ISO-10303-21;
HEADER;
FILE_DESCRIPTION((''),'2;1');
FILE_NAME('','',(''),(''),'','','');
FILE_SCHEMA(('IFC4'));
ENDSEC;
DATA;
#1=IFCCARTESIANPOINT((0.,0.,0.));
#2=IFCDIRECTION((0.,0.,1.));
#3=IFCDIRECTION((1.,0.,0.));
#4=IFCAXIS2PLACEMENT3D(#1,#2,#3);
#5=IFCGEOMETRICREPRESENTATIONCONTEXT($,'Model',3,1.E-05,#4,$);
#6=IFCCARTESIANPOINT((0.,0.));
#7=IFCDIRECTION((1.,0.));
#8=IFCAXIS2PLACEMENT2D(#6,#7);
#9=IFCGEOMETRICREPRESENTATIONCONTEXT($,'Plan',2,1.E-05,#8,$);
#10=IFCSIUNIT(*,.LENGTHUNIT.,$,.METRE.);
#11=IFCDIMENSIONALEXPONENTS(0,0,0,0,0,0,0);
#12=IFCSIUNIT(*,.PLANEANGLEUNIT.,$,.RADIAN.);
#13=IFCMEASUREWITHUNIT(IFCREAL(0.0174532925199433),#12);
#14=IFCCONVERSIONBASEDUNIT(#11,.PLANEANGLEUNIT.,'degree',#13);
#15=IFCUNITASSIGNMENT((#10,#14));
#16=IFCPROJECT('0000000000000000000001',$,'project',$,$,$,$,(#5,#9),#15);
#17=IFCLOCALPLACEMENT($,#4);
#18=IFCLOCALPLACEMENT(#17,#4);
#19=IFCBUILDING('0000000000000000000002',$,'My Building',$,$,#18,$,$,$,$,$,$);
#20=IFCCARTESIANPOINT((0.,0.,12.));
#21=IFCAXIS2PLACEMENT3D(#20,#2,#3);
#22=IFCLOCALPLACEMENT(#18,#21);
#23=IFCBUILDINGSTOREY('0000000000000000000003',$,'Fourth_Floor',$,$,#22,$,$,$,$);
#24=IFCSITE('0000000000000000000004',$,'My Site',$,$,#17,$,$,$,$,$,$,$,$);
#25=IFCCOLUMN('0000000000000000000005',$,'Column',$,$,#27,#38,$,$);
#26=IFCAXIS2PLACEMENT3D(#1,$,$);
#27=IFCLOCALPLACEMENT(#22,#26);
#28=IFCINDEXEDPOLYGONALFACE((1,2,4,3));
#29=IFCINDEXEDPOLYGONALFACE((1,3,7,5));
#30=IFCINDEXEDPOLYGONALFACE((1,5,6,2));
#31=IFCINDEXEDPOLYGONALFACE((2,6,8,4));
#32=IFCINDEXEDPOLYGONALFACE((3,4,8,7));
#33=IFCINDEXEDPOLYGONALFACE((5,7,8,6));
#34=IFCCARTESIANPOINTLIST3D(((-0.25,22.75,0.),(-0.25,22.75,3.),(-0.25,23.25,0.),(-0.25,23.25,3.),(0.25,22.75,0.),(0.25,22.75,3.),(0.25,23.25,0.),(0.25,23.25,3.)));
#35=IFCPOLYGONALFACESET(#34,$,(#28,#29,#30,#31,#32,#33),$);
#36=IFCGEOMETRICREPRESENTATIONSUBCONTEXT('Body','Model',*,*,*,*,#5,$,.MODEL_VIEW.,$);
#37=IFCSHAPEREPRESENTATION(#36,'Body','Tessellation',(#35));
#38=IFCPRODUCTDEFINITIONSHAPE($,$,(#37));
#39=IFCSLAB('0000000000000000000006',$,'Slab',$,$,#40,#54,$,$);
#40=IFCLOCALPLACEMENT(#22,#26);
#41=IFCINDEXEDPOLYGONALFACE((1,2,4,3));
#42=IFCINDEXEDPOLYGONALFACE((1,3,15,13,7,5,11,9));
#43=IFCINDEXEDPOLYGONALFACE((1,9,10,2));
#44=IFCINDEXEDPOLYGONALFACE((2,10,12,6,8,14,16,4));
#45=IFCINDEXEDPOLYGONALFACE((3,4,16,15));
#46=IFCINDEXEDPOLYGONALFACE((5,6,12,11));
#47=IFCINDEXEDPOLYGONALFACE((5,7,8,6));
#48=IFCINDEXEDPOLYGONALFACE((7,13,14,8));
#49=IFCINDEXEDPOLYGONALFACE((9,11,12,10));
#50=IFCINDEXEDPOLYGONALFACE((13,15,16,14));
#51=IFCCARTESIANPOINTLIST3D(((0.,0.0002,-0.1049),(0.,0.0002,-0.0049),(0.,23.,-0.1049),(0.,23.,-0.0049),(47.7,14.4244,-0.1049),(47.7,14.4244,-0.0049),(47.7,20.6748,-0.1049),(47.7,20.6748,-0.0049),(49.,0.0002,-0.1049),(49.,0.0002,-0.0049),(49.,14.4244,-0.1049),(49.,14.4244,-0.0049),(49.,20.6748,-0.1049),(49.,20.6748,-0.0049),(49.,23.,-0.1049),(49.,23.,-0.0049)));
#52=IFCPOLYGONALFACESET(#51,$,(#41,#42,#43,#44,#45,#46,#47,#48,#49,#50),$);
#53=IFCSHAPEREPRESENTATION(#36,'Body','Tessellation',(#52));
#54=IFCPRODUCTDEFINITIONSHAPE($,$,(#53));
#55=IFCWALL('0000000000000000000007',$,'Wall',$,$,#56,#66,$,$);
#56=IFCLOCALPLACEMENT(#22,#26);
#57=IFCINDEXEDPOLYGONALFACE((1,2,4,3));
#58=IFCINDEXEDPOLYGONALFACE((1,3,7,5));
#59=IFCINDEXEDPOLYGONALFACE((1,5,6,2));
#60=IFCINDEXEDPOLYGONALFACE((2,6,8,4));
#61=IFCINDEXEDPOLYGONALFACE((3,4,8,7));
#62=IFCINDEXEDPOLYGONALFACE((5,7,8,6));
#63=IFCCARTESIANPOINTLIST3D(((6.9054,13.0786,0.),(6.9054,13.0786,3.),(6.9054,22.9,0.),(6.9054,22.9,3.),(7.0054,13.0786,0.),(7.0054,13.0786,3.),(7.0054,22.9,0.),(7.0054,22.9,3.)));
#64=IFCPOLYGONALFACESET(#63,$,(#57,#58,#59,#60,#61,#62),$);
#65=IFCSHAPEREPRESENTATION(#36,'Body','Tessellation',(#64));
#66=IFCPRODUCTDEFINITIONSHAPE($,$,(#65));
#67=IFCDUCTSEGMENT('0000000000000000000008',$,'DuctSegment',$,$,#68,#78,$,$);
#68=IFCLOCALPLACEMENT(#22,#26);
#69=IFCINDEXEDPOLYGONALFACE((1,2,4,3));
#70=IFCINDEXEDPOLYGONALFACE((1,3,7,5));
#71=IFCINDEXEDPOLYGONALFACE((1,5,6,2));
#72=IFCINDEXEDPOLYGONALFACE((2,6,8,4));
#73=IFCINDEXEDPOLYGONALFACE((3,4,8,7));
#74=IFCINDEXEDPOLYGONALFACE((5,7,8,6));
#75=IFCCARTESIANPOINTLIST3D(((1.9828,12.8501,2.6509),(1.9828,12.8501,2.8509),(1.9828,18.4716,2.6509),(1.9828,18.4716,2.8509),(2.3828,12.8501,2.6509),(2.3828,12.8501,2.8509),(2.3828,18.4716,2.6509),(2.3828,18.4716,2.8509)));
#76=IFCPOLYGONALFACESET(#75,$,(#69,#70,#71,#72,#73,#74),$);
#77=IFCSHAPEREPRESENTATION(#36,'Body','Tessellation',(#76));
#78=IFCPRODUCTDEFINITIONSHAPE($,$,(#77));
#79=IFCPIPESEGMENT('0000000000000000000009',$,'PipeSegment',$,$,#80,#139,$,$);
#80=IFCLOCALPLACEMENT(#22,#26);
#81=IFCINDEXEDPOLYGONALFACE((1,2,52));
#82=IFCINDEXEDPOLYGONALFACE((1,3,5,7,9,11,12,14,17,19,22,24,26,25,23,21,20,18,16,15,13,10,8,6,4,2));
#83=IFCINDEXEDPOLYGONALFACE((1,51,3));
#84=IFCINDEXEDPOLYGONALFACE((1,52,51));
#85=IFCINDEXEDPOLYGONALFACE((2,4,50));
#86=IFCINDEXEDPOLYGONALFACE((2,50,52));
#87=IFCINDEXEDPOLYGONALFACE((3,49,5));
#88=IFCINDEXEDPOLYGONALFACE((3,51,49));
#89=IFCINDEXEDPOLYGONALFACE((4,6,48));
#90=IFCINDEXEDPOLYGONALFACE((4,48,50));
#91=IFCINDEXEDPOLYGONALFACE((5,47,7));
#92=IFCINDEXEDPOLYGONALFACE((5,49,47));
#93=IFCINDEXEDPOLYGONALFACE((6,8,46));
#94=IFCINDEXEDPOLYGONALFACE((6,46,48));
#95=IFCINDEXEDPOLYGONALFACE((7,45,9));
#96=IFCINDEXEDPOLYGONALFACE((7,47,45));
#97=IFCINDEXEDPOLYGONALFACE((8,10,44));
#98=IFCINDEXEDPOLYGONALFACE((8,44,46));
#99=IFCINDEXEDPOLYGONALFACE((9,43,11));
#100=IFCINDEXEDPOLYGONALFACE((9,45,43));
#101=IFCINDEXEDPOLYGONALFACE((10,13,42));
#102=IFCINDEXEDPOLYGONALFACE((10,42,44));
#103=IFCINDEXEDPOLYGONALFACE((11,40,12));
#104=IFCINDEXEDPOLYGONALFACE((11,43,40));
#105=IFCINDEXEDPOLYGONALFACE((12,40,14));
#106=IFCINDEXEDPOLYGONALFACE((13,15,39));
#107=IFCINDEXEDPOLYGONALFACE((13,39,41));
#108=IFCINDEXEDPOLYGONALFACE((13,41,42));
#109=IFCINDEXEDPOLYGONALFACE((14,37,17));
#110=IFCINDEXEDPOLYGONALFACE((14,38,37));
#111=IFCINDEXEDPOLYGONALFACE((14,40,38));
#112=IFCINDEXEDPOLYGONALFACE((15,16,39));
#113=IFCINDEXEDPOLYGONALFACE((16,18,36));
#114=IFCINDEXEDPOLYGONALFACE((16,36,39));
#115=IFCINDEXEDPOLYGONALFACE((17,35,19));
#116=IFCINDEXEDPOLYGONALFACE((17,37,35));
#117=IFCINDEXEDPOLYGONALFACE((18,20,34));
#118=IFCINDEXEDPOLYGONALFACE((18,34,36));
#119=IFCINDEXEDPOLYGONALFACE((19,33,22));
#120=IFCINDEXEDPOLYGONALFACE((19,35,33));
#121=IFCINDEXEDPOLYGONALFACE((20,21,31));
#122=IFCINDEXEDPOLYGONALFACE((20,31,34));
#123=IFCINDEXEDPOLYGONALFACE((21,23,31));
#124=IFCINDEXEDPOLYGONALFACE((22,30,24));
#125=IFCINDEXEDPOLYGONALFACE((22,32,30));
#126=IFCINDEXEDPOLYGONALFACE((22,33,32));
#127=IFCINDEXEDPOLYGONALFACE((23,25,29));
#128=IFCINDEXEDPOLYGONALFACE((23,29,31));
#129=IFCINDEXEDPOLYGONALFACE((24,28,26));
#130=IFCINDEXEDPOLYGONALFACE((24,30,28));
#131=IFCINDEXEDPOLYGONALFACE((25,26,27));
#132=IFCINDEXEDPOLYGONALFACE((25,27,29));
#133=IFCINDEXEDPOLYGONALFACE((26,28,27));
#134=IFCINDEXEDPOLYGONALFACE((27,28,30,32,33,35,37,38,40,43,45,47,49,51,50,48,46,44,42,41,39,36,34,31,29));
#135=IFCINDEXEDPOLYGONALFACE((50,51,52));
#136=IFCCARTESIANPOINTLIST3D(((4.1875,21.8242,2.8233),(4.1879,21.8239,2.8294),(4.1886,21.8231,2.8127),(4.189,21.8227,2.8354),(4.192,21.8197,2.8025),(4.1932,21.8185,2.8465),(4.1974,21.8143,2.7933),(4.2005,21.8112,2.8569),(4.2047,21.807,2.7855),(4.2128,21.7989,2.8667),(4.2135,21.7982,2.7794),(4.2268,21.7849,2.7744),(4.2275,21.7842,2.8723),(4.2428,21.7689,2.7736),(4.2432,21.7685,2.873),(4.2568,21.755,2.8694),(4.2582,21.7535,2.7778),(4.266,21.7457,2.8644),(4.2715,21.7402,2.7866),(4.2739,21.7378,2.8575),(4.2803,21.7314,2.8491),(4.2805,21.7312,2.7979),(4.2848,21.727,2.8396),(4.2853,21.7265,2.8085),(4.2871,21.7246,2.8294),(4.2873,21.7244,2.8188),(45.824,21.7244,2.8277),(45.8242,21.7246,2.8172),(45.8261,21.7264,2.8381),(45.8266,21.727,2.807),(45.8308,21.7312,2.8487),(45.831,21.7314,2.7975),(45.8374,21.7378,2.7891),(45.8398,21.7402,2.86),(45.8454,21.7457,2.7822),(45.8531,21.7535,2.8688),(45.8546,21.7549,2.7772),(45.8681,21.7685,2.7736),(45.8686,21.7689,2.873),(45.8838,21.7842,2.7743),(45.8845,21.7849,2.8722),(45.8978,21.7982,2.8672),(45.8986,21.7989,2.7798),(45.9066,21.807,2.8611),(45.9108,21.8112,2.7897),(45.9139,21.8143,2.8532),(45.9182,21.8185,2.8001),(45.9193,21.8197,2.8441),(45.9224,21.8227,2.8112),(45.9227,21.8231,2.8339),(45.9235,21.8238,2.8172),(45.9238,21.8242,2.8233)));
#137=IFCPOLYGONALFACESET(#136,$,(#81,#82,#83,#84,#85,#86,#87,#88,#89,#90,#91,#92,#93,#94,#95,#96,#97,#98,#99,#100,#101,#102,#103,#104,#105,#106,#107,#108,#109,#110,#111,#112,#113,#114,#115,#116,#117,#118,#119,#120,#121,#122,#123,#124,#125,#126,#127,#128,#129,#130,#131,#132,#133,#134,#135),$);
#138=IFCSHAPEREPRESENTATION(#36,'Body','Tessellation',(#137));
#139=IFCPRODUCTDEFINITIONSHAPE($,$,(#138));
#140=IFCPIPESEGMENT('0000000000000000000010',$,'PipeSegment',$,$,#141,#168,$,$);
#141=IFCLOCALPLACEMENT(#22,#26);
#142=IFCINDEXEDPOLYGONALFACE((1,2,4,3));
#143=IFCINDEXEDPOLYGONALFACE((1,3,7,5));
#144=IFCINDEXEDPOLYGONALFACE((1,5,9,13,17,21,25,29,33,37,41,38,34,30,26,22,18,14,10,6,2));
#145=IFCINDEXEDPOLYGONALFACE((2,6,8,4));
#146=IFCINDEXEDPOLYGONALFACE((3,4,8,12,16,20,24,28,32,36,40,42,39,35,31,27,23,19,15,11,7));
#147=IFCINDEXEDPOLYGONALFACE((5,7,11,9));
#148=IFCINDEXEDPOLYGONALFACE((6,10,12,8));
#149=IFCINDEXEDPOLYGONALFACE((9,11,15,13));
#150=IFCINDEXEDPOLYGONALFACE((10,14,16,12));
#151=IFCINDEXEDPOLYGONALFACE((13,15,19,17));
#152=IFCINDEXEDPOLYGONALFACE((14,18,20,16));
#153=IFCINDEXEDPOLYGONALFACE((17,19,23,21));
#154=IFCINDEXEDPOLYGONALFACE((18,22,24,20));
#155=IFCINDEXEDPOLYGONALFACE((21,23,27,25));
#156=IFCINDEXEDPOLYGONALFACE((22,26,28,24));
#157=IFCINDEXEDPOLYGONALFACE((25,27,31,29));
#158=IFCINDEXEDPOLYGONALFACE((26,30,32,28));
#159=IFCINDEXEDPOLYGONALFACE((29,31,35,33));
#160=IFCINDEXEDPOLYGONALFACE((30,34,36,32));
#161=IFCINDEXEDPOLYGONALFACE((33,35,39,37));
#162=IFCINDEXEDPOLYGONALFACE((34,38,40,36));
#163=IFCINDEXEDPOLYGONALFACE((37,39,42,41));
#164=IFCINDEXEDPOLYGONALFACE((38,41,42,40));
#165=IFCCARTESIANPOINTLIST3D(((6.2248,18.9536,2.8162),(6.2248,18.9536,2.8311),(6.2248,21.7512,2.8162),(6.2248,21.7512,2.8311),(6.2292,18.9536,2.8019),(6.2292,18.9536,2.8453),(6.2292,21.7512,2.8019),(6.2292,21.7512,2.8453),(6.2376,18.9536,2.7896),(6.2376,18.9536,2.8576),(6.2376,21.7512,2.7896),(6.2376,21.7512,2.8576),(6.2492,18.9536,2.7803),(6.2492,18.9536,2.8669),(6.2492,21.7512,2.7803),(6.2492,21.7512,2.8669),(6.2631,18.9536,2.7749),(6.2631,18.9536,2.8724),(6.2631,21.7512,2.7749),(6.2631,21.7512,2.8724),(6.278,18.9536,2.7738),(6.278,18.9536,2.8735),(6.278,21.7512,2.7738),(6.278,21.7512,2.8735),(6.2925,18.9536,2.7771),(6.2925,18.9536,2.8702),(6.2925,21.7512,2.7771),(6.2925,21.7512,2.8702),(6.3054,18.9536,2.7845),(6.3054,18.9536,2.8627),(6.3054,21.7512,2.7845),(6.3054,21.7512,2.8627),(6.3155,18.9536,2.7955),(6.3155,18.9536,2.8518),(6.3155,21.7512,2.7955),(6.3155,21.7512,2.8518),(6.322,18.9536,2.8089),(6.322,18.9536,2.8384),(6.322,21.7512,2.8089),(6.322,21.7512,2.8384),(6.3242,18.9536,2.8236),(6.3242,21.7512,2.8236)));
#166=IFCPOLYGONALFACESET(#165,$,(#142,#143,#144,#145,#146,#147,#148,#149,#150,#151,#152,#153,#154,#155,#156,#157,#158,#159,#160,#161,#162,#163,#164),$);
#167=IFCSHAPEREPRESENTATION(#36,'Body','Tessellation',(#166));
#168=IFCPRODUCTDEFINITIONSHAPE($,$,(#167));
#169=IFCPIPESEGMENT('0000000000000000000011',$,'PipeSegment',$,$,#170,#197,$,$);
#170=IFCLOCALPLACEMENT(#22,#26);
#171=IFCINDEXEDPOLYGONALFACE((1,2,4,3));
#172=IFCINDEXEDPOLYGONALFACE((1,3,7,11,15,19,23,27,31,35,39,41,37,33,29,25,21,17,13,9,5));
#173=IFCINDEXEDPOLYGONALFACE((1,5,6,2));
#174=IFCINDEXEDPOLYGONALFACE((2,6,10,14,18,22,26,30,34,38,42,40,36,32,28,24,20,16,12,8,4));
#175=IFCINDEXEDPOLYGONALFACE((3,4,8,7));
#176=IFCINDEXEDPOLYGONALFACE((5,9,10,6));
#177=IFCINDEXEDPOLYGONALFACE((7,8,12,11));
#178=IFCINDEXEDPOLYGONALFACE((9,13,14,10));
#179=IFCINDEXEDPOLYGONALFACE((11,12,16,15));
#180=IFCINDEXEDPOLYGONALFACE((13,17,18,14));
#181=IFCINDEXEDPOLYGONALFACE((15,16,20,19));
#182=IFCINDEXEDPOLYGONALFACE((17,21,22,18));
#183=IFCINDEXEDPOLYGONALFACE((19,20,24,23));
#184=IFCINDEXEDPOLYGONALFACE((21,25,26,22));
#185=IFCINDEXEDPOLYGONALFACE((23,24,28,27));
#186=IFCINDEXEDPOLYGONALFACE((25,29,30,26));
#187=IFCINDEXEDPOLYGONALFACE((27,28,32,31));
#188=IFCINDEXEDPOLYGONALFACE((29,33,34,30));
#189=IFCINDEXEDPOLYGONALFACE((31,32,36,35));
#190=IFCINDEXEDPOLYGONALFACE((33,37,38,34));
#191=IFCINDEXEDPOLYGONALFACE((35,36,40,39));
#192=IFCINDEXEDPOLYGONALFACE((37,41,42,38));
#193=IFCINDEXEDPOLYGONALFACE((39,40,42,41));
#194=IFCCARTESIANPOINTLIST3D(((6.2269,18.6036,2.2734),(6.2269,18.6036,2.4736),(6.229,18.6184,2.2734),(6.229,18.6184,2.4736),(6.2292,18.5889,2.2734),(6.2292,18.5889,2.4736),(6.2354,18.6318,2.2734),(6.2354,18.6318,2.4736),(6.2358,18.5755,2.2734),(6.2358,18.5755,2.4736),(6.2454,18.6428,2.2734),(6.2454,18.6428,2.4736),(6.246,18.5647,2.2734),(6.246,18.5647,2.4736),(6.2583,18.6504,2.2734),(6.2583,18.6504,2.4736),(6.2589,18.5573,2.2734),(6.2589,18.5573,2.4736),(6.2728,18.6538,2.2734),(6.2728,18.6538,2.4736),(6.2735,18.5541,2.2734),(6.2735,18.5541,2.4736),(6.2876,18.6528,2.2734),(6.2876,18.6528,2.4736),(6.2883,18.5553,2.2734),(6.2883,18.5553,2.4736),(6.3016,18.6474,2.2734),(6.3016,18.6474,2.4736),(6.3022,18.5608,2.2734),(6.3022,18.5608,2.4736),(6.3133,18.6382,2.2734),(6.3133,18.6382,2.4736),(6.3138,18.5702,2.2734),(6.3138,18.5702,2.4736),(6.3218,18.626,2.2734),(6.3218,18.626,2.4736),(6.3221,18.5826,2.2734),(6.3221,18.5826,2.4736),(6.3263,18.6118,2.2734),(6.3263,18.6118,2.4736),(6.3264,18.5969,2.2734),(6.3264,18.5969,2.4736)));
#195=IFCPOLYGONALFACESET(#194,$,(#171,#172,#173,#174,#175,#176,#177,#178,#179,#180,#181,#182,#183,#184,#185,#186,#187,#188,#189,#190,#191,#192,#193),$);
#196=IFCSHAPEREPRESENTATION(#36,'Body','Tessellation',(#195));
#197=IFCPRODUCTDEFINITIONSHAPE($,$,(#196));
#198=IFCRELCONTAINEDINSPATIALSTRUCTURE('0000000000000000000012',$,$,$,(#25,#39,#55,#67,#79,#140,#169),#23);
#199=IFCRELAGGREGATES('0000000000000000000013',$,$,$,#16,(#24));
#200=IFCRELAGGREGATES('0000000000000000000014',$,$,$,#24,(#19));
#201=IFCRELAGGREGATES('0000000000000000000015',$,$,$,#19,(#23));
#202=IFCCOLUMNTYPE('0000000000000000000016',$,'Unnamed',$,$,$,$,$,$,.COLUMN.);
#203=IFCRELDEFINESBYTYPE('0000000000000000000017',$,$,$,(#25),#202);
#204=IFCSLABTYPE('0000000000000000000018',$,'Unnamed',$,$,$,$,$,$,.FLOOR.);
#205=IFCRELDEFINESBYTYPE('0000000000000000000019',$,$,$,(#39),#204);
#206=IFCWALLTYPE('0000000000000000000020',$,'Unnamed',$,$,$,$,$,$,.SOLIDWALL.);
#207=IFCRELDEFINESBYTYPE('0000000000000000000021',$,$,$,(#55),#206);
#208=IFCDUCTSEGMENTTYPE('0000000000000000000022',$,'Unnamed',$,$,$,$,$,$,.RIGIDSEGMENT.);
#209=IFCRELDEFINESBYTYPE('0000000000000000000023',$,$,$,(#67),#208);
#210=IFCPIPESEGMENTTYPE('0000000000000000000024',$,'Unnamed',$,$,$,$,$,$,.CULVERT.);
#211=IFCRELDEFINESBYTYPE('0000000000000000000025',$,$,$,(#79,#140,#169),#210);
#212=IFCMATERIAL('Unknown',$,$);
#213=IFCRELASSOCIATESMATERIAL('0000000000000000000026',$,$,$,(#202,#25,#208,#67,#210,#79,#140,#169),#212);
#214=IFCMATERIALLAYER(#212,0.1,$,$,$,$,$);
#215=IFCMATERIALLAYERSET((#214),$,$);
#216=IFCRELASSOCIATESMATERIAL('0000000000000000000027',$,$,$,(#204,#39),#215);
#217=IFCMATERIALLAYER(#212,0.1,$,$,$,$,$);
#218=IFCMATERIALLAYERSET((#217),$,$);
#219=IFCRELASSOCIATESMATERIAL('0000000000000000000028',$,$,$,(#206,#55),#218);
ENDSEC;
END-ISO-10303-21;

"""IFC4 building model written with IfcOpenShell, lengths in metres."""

from ifc_helpers import new_model, entity, si_unit, converted_unit, frame, origin_with_axes, origin_2d_with_axis, place, context, subcontext, project, spatial, line, indexed_curve, rectangle, circle, outline, extrude, clip, halfspace, material, layer, layer_set, layer_usage, material_profile, profile_set, profile_usage, type_object, element, save


model = new_model("IFC4")

# Units and contexts
model_context = context("Model", 3, precision=1e-05, world=origin_with_axes())
plan_context = context("Plan", 2, precision=1e-05, world=origin_2d_with_axis())
body_context_1 = subcontext(model_context, "Body", "Model", "MODEL_VIEW")
ifc_project = project(units=[si_unit("LENGTHUNIT", "METRE"), converted_unit("PLANEANGLEUNIT", "degree", entity("IfcReal", 0.0174532925199433), si_unit("PLANEANGLEUNIT", "RADIAN"), dimensions=[0, 0, 0, 0, 0, 0, 0])], contexts=[model_context, plan_context])

# Site, building, storey
site_placement = place(None, origin_with_axes())
site = spatial("IfcSite", under=ifc_project, at=site_placement, Name="My Site")
building_placement = place(site_placement, origin_with_axes())
building = spatial("IfcBuilding", under=site, at=building_placement, Name="My Building")
storey_placement = place(building_placement, frame((0.0, 0.0, 12.0), z_axis=(0.0, 0.0, 1.0), x_axis=(1.0, 0.0, 0.0)))
storey = spatial("IfcBuildingStorey", under=building, at=storey_placement, Name="Fourth_Floor")

# Column
ifc_material = material(Name="Unknown")
ifc_material_profile_1 = material_profile(ifc_material, rectangle(XDim=0.5, YDim=0.5))
ifc_profile_set_1 = profile_set([ifc_material_profile_1])
ifc_profile_usage_1 = profile_usage(ifc_profile_set_1, cardinal=5)
column_type = type_object("IfcColumnType", Name="Unnamed", PredefinedType="COLUMN", material=ifc_profile_set_1)
column_placement = place(storey_placement, frame((0.0, 23.0, 0.0), z_axis=(0.0, 0.0, 1.0), x_axis=(1.0, 0.0, 0.0)))
element("IfcColumn", 1, at=column_placement, inside=storey, type_object=column_type, material=ifc_profile_usage_1, Name="Column", context=body_context_1, shape_type="SweptSolid", body=[
    extrude(rectangle(XDim=0.5, YDim=0.5), origin_with_axes(), (0.0, 0.0, 1.0), 3.0),
])

# Slab
ifc_layer_1 = layer(ifc_material, 0.1)
ifc_layer_set_1 = layer_set([ifc_layer_1])
ifc_layer_usage_1 = layer_usage(ifc_layer_set_1, "AXIS3", "POSITIVE", -0.1)
slab_type = type_object("IfcSlabType", Name="Unnamed", PredefinedType="FLOOR", material=ifc_layer_set_1)
slab_placement = place(storey_placement, frame((0.0, 23.0, -0.0049), z_axis=(0.0, 0.0, 1.0), x_axis=(1.0, 0.0, 0.0)))
element("IfcSlab", 2, at=slab_placement, inside=storey, type_object=slab_type, material=ifc_layer_usage_1, Name="Slab", context=body_context_1, shape_type="SweptSolid", body=[
    extrude(outline(indexed_curve([(0.0, 0.0), (49.0, 0.0), (49.0, -2.3252), (47.7, -2.3252), (47.7, -8.5756), (49.0, -8.5756), (49.0, -22.9998), (0.0, -22.9998), (0.0, 0.0)])), frame((0.0, 0.0, -0.1), z_axis=(0.0, 0.0, 1.0), x_axis=(1.0, 0.0, 0.0)), (0.0, 0.0, 1.0), 0.1),
])

# Shared definitions
ifc_layer_2 = layer(ifc_material, 0.1)
ifc_layer_set_2 = layer_set([ifc_layer_2])
wall_type = type_object("IfcWallType", Name="Unnamed", PredefinedType="SOLIDWALL", material=ifc_layer_set_2)

# Wall
ifc_layer_usage_2 = layer_usage(ifc_layer_set_2, "AXIS2", "POSITIVE", 0.0)
wall_1_placement = place(storey_placement, frame((6.9054, 22.9, 0.0), z_axis=(0.0, 0.0, 1.0), x_axis=(0.0, -1.0, 0.0)))
element("IfcWall", 3, at=wall_1_placement, inside=storey, type_object=wall_type, material=ifc_layer_usage_2, Name="Wall", context=body_context_1, shape_type="SweptSolid", body=[
    extrude(outline(indexed_curve([(0.0, 0.0), (0.0, 0.1), (9.8214, 0.1), (9.8214, 0.0)], segments=[line(1, 2, 3, 4, 1)])), origin_with_axes(), (0.0, 0.0, 1.0), 3.0),
])

# Duct segment
ifc_material_profile_2 = material_profile(ifc_material, rectangle(XDim=0.4, YDim=0.2))
ifc_profile_set_2 = profile_set([ifc_material_profile_2])
ifc_profile_usage_2 = profile_usage(ifc_profile_set_2, cardinal=5)
duct_segment_type = type_object("IfcDuctSegmentType", Name="Unnamed", PredefinedType="RIGIDSEGMENT", material=ifc_profile_set_2)
duct_segment_placement = place(storey_placement, frame((2.1828, 18.4716, 2.7509), z_axis=(0.0, -1.0, 0.0), x_axis=(1.0, 0.0, 0.0)))
element("IfcDuctSegment", 4, at=duct_segment_placement, inside=storey, type_object=duct_segment_type, material=ifc_profile_usage_2, Name="DuctSegment", context=body_context_1, shape_type="SweptSolid", body=[
    extrude(rectangle(XDim=0.4, YDim=0.2), origin_with_axes(), (0.0, 0.0, 1.0), 5.6215),
])

# Pipe segments
ifc_material_profile_3 = material_profile(ifc_material, circle(Radius=0.05))
ifc_profile_set_3 = profile_set([ifc_material_profile_3])
ifc_profile_usage_3 = profile_usage(ifc_profile_set_3, cardinal=5)
pipe_segment_type = type_object("IfcPipeSegmentType", Name="Unnamed", PredefinedType="CULVERT", material=ifc_profile_set_3)
pipe_segment_1_placement = place(storey_placement, frame((4.1875, 21.7742, 2.8233), z_axis=(1.0, 0.0, 0.0), x_axis=(0.0, 1.0, 0.0)))
element("IfcPipeSegment", 5, at=pipe_segment_1_placement, inside=storey, type_object=pipe_segment_type, material=ifc_profile_usage_3, Name="PipeSegment", context=body_context_1, shape_type="Clipping", body=[
    clip(clip(extrude(circle(Radius=0.05), origin_with_axes(), (0.0, 0.0, 1.0), 41.7363), halfspace(frame((0.05, -3.0, 41.7364), z_axis=(-0.707107, 0.0, 0.707107), x_axis=(0.0, 1.0, 0.0)), False)), halfspace(frame((0.05, -3.0, 0.0), z_axis=(-0.707114, 0.0, -0.7071), x_axis=(0.0, 1.0, 0.0)), False)),
])
ifc_profile_usage_4 = profile_usage(ifc_profile_set_3, cardinal=5)
pipe_segment_2_placement = place(storey_placement, frame((6.2742, 21.7512, 2.8236), z_axis=(0.0, -1.0, 0.0), x_axis=(1.0, 0.0, 0.0)))
element("IfcPipeSegment", 6, at=pipe_segment_2_placement, inside=storey, type_object=pipe_segment_type, material=ifc_profile_usage_4, Name="PipeSegment", context=body_context_1, shape_type="SweptSolid", body=[
    extrude(circle(Radius=0.05), origin_with_axes(), (0.0, 0.0, 1.0), 2.7976),
])
ifc_profile_usage_5 = profile_usage(ifc_profile_set_3, cardinal=5)
pipe_segment_3_placement = place(storey_placement, frame((6.2769, 18.604, 2.4736), z_axis=(-0.000001, 0.0, -1.0), x_axis=(-0.999975, -0.007084, 0.000001)))
element("IfcPipeSegment", 7, at=pipe_segment_3_placement, inside=storey, type_object=pipe_segment_type, material=ifc_profile_usage_5, Name="PipeSegment", context=body_context_1, shape_type="SweptSolid", body=[
    extrude(circle(Radius=0.05), origin_with_axes(), (0.0, 0.0, 1.0), 0.2002),
])

save(model, "model.ifc")
